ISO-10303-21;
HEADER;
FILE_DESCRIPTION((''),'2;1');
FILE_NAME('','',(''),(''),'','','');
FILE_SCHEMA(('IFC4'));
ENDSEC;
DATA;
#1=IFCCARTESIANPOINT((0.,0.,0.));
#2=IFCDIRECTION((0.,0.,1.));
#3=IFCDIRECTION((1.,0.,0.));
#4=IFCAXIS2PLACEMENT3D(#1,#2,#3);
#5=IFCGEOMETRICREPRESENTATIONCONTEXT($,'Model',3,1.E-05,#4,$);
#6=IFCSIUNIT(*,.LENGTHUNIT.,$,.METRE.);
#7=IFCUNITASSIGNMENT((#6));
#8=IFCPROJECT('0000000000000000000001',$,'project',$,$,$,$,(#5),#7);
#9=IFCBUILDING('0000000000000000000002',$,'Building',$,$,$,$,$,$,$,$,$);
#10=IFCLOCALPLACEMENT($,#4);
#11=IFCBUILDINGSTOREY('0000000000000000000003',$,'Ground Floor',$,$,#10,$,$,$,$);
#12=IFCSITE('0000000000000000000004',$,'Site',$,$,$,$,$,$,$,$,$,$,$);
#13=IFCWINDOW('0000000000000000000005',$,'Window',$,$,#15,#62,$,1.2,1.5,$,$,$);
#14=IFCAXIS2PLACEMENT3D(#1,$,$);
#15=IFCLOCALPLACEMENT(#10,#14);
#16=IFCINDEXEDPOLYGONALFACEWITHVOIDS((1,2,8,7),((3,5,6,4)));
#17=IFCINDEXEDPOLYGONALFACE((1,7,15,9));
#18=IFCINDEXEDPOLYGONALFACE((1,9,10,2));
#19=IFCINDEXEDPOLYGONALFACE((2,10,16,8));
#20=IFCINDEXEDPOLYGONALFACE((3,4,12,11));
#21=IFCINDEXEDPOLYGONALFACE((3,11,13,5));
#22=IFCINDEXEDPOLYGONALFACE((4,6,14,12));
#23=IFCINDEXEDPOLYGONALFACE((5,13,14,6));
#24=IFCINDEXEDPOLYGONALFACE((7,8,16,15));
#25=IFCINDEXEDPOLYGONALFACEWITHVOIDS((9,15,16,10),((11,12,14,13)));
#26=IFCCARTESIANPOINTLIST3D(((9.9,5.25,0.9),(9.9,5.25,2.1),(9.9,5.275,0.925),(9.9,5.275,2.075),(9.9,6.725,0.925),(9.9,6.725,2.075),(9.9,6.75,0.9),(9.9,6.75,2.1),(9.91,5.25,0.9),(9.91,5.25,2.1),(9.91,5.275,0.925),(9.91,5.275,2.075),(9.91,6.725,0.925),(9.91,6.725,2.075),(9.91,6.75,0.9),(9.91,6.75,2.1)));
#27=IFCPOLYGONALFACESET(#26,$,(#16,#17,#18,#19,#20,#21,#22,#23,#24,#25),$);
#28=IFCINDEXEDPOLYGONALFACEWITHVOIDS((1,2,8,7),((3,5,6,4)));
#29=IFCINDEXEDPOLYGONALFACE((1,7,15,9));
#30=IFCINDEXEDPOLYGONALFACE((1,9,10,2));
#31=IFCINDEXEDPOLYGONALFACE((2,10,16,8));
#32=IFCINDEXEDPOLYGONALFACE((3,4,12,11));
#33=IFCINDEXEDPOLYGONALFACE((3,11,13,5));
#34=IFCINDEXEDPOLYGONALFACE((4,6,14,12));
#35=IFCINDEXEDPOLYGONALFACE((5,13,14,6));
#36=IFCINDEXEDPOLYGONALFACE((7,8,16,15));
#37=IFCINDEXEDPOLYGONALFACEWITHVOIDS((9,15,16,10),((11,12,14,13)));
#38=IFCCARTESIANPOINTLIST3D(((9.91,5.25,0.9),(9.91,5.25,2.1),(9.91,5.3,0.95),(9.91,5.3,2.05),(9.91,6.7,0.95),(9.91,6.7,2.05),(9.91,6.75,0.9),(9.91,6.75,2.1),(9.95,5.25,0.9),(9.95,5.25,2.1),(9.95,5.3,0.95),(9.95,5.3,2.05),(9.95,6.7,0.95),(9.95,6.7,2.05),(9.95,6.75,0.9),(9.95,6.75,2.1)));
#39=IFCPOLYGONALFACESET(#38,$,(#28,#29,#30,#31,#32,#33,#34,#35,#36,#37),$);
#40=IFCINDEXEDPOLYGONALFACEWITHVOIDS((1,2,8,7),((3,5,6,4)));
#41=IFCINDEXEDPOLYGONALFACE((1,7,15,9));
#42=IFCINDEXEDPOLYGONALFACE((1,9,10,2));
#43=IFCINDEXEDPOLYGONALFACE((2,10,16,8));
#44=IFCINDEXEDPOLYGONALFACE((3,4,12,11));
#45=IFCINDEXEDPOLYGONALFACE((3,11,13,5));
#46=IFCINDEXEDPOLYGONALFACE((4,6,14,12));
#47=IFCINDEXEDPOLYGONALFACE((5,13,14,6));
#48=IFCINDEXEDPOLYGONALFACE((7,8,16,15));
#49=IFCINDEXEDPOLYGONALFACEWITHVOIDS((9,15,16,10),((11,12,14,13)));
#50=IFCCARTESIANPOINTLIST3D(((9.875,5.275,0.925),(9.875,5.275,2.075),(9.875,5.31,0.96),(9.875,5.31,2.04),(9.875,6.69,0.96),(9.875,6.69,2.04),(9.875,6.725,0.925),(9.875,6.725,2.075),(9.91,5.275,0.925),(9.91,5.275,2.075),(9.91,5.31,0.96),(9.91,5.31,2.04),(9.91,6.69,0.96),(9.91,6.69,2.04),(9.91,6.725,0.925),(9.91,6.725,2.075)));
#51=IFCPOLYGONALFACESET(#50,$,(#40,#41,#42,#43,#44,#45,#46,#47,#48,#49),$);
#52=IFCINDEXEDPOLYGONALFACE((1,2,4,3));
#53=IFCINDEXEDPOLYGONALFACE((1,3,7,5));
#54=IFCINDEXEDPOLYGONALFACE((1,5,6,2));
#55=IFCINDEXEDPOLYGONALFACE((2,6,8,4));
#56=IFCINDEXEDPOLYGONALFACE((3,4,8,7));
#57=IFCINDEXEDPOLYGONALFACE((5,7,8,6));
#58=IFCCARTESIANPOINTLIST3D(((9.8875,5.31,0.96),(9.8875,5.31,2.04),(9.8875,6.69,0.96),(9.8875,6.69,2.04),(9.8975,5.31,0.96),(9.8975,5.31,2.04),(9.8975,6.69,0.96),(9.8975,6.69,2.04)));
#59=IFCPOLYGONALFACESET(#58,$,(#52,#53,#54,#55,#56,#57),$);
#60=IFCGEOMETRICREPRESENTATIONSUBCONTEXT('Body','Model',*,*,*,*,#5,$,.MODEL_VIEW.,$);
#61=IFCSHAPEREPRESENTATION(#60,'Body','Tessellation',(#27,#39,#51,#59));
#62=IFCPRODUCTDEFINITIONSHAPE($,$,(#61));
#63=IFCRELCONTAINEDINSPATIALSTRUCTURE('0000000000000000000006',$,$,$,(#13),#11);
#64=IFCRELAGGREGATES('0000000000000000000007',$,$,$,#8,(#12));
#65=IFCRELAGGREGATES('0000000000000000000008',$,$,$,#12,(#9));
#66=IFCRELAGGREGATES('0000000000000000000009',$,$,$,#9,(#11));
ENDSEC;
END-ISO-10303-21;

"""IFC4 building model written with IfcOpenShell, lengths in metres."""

from ifc_helpers import new_model, si_unit, frame, origin_with_axes, place, context, subcontext, project, spatial, line, indexed_curve, outline, extrude, element, save


model = new_model("IFC4")

# Units and contexts
model_context = context("Model", 3, precision=1e-05, world=origin_with_axes())
body_context = subcontext(model_context, "Body", "Model", "MODEL_VIEW")
ifc_project = project(units=[si_unit("LENGTHUNIT", "METRE")], contexts=[model_context])

# Site, building, storey
site = spatial("IfcSite", under=ifc_project, Name="Site")
building = spatial("IfcBuilding", under=site, Name="Building")
storey_placement = place(None, origin_with_axes())
storey = spatial("IfcBuildingStorey", under=building, at=storey_placement, Name="Ground Floor")

# Window
for number, where, z_axis, x_axis, name in (
    (1, (10.0, 5.25, 0.9), (0.0, 0.0, 1.0), (0.0, 1.0, 0.0), "Window"),
):
    element("IfcWindow", number, at=place(storey_placement, frame(where, z_axis=z_axis, x_axis=x_axis)), inside=storey, Name=name, OverallHeight=1.2, OverallWidth=1.5, context=body_context, shape_type="SweptSolid", body=[
        extrude(outline(indexed_curve([(0.0, 0.0), (1.5, 0.0), (1.5, 1.2), (0.0, 1.2)], segments=[line(1, 2, 3, 4, 1)]), holes=[indexed_curve([(0.025, 0.025), (1.475, 0.025), (1.475, 1.175), (0.025, 1.175)], segments=[line(1, 2, 3, 4, 1)])]), frame((0.0, 0.09, 0.0), z_axis=(0.0, -1.0, 0.0), x_axis=(1.0, 0.0, 0.0)), (0.0, 0.0, -1.0), 0.01),
        extrude(outline(indexed_curve([(0.0, 0.0), (1.5, 0.0), (1.5, 1.2), (0.0, 1.2)], segments=[line(1, 2, 3, 4, 1)]), holes=[indexed_curve([(0.05, 0.05), (1.45, 0.05), (1.45, 1.15), (0.05, 1.15)], segments=[line(1, 2, 3, 4, 1)])]), frame((0.0, 0.05, 0.0), z_axis=(0.0, -1.0, 0.0), x_axis=(1.0, 0.0, 0.0)), (0.0, 0.0, -1.0), 0.04),
        extrude(outline(indexed_curve([(0.0, 0.0), (1.45, 0.0), (1.45, 1.15), (0.0, 1.15)], segments=[line(1, 2, 3, 4, 1)]), holes=[indexed_curve([(0.035, 0.035), (1.415, 0.035), (1.415, 1.115), (0.035, 1.115)], segments=[line(1, 2, 3, 4, 1)])]), frame((0.025, 0.09, 0.025), z_axis=(0.0, -1.0, 0.0), x_axis=(1.0, 0.0, 0.0)), (0.0, 0.0, -1.0), 0.035),
        extrude(outline(indexed_curve([(0.035, 0.035), (1.415, 0.035), (1.415, 1.115), (0.035, 1.115)], segments=[line(1, 2, 3, 4, 1)])), frame((0.025, 0.1025, 0.025), z_axis=(0.0, -1.0, 0.0), x_axis=(1.0, 0.0, 0.0)), (0.0, 0.0, -1.0), 0.01),
    ])

save(model, "model.ifc")
